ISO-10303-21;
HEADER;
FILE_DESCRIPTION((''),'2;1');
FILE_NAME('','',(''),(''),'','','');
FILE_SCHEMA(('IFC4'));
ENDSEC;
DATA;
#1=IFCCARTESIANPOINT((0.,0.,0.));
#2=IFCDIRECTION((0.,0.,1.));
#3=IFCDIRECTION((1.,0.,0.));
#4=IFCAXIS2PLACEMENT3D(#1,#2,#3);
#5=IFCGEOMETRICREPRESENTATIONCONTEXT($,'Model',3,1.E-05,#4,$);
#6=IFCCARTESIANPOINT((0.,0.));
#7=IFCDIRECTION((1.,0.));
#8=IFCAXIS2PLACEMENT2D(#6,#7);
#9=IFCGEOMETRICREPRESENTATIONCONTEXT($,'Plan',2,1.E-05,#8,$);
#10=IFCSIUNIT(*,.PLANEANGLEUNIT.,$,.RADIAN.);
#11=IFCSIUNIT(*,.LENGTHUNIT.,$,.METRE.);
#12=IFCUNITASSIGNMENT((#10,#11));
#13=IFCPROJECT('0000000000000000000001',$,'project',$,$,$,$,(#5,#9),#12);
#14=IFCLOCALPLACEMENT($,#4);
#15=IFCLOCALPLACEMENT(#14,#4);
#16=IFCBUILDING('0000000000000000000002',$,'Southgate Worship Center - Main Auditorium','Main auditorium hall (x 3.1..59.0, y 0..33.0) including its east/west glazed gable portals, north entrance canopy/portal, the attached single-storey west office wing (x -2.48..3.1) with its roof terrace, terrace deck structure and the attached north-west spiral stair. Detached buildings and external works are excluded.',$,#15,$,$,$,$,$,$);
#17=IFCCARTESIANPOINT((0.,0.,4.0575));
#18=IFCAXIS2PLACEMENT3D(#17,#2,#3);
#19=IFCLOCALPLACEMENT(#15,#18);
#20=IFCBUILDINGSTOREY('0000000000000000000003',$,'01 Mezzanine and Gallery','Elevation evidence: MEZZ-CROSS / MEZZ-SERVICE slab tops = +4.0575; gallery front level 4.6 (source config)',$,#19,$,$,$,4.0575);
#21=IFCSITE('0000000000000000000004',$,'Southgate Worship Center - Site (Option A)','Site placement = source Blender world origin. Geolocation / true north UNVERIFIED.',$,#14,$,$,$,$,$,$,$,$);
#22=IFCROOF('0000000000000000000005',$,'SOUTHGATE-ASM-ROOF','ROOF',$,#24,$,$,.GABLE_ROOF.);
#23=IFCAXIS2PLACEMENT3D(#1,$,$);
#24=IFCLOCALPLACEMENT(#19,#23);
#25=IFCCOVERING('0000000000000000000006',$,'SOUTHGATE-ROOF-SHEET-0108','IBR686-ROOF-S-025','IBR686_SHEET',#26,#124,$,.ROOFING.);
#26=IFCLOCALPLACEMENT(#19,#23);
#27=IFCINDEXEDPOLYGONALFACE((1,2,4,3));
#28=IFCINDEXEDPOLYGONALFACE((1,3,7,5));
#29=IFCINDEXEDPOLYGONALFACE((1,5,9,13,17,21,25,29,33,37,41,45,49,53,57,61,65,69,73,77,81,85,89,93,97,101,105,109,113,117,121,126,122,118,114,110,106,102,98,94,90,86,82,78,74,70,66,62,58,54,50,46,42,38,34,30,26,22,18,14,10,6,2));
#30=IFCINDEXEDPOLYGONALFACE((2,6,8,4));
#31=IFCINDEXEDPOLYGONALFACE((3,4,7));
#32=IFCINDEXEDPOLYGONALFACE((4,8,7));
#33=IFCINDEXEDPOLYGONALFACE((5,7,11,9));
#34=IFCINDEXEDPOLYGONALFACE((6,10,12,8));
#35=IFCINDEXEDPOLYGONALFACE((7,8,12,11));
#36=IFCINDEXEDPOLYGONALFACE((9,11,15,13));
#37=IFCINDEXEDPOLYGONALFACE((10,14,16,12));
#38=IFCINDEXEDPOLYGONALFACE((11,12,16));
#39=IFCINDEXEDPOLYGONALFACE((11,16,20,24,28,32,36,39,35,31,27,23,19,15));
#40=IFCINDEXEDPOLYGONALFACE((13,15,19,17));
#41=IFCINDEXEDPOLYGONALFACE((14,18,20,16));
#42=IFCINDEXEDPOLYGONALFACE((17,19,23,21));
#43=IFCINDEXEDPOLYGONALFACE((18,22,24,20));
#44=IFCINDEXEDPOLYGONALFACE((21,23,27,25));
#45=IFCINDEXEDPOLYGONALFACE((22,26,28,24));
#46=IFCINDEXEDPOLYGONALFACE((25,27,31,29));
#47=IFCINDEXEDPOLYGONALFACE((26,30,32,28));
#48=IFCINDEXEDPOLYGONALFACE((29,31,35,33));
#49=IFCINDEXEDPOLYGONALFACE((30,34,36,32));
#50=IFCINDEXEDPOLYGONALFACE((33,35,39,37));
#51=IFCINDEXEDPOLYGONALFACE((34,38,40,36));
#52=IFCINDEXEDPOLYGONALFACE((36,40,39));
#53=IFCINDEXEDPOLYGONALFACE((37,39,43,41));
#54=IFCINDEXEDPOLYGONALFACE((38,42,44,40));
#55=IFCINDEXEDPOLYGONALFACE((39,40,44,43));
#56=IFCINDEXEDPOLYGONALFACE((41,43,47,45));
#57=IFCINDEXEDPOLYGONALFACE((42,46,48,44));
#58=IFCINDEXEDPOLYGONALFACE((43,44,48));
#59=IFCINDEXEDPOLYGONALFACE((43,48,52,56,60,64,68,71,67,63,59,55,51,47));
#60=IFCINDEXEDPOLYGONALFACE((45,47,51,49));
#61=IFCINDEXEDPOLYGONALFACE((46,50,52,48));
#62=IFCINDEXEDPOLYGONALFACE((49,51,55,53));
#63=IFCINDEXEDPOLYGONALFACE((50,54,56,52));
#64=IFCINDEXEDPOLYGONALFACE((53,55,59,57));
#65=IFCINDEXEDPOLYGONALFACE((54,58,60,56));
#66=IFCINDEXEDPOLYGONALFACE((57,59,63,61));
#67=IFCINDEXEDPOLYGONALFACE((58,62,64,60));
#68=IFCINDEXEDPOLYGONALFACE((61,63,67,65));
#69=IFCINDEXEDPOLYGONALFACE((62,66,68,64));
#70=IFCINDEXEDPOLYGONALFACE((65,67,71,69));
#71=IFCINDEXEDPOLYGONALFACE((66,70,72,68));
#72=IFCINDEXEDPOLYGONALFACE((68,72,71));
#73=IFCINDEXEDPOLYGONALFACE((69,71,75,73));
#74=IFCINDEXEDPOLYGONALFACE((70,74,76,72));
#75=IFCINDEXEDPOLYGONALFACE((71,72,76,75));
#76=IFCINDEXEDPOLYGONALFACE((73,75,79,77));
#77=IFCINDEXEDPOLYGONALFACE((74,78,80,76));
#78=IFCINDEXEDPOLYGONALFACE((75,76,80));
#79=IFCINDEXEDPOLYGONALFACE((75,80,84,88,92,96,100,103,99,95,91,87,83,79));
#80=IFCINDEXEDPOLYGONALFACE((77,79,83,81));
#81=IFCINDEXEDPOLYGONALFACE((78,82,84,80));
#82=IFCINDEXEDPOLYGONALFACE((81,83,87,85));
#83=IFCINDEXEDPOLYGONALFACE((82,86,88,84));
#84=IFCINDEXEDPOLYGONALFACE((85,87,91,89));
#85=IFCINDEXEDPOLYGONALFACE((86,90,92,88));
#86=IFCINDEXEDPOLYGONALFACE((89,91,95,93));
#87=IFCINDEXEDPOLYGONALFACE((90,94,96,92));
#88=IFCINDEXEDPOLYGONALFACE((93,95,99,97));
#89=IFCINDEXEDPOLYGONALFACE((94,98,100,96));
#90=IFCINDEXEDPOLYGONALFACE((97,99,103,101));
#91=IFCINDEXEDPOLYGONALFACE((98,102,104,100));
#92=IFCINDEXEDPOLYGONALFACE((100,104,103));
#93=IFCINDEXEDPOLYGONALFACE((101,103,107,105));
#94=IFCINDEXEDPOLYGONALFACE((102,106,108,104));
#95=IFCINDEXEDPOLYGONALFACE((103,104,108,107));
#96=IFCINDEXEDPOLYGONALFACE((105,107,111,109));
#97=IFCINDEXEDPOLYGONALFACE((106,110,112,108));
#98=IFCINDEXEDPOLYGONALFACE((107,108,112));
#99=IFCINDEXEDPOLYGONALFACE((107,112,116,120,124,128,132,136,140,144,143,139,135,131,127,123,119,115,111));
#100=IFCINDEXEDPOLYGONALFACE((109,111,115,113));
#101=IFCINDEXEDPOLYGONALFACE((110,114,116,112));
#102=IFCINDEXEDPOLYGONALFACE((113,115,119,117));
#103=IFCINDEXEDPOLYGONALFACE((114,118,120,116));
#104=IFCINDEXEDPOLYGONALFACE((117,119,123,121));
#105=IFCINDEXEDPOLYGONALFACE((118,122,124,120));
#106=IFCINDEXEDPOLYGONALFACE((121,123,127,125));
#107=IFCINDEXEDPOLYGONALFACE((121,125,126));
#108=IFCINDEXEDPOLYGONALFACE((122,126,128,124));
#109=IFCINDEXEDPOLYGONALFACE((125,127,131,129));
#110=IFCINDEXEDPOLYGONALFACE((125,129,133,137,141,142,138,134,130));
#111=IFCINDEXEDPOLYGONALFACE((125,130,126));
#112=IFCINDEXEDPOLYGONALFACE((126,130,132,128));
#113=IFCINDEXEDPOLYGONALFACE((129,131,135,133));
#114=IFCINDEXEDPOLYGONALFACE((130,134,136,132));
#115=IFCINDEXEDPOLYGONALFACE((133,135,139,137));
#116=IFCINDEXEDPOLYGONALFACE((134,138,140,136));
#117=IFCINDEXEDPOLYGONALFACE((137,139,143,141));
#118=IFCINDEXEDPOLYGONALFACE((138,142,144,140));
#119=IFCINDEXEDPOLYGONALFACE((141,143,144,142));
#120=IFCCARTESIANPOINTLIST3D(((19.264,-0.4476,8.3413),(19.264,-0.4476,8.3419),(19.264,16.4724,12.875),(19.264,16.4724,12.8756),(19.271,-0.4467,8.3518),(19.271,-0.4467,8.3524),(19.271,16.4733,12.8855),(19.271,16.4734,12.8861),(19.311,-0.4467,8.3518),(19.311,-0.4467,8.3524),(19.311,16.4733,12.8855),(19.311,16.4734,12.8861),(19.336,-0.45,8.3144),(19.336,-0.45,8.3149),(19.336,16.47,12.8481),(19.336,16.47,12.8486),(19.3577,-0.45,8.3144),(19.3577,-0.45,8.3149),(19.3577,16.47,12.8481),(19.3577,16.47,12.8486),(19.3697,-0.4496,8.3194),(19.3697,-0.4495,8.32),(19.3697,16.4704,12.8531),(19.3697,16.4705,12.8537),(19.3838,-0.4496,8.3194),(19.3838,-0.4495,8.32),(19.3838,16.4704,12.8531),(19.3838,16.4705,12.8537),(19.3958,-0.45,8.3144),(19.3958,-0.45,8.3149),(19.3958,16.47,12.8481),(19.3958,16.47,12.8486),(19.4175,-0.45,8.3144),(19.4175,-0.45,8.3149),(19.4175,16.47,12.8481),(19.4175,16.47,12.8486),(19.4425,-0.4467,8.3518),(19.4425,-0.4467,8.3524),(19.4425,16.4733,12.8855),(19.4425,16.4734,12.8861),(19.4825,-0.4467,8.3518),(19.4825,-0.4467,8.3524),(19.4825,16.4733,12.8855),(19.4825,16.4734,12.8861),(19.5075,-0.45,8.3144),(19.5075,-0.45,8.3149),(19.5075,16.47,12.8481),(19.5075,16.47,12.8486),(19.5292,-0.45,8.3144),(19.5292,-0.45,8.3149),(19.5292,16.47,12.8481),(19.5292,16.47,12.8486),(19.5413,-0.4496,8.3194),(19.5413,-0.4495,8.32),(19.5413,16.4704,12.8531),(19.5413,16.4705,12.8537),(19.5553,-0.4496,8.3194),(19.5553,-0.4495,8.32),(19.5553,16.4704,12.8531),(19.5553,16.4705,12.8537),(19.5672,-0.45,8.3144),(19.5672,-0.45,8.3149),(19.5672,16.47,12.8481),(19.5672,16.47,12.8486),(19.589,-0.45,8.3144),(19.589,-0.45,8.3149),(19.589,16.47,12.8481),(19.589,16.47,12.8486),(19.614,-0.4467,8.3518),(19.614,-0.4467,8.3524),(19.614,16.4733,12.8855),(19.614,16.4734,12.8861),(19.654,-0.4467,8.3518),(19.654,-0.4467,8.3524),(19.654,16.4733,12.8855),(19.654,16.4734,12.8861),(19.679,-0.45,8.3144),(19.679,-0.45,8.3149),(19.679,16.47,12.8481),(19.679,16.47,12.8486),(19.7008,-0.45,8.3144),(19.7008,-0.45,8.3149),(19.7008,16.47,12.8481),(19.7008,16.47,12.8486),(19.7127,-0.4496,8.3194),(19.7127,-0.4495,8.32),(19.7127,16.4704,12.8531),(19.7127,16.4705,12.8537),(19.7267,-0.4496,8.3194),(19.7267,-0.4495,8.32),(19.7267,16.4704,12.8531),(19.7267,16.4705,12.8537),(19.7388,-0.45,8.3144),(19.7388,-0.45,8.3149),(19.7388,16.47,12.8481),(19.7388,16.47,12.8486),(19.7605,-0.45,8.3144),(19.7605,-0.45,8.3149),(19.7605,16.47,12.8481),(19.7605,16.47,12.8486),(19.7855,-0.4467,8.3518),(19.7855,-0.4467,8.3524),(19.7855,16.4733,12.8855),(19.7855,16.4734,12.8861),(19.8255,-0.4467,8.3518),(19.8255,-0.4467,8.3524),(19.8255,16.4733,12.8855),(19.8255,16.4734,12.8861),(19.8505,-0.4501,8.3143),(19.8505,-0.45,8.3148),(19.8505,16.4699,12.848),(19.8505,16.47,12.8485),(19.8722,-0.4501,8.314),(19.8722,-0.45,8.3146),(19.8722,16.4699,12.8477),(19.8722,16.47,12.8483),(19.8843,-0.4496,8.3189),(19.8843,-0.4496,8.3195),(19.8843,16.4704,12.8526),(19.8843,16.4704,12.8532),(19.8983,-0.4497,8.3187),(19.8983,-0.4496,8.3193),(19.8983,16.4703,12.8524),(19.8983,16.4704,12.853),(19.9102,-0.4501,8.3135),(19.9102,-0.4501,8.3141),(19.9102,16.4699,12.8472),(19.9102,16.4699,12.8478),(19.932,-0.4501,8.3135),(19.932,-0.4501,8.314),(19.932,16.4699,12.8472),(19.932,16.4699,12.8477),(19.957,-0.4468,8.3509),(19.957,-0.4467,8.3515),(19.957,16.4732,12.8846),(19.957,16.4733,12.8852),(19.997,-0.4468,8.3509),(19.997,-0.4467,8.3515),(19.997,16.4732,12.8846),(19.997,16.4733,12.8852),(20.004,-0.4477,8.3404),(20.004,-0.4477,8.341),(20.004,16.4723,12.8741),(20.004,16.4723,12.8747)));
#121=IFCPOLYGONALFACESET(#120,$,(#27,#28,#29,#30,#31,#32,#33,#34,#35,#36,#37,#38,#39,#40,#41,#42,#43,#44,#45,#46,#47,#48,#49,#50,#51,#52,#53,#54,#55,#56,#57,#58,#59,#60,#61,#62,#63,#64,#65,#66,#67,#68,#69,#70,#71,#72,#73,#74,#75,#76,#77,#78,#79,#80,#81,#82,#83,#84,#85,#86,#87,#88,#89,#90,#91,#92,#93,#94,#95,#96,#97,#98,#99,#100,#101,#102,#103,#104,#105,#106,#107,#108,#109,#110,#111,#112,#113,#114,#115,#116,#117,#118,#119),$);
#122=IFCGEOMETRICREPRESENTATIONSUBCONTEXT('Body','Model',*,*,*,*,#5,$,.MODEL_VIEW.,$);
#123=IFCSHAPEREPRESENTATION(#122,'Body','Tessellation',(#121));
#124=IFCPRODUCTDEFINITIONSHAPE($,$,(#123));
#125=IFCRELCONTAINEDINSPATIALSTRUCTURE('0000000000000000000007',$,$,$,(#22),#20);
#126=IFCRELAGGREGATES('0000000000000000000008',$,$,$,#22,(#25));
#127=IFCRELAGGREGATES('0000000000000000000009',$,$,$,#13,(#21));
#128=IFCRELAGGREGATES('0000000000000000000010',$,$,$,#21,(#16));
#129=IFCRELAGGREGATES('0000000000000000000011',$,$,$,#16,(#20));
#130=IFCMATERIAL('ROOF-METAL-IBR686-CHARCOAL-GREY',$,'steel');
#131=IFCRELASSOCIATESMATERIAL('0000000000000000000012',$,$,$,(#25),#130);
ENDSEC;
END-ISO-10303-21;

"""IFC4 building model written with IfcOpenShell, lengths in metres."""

from ifc_helpers import new_model, si_unit, frame, origin_with_axes, origin_2d_with_axis, place, context, subcontext, project, spatial, indexed_curve, outline, extrude, clip, halfspace, material, element, aggregate, save


model = new_model("IFC4")

# Units and contexts
model_context = context("Model", 3, precision=1e-05, world=origin_with_axes())
plan_context = context("Plan", 2, precision=1e-05, world=origin_2d_with_axis())
body_context = subcontext(model_context, "Body", "Model", "MODEL_VIEW")
ifc_project = project(units=[si_unit("PLANEANGLEUNIT", "RADIAN"), si_unit("LENGTHUNIT", "METRE")], contexts=[model_context, plan_context])

# Site, building, storey
site_placement = place(None, origin_with_axes())
site = spatial("IfcSite", under=ifc_project, at=site_placement, Name="Southgate Worship Center - Site (Option A)", Description="Site placement = source Blender world origin. Geolocation / true north UNVERIFIED.")
building_placement = place(site_placement, origin_with_axes())
building = spatial("IfcBuilding", under=site, at=building_placement, Name="Southgate Worship Center - Main Auditorium", Description="Main auditorium hall (x 3.1..59.0, y 0..33.0) including its east/west glazed gable portals, north entrance canopy/portal, the attached single-storey west office wing (x -2.48..3.1) with its roof terrace, terrace deck structure and the attached north-west spiral stair. Detached buildings and external works are excluded.")
storey_placement = place(building_placement, frame((0.0, 0.0, 4.0575), z_axis=(0.0, 0.0, 1.0), x_axis=(1.0, 0.0, 0.0)))
storey = spatial("IfcBuildingStorey", under=building, at=storey_placement, Name="01 Mezzanine and Gallery", Description="Elevation evidence: MEZZ-CROSS / MEZZ-SERVICE slab tops = +4.0575; gallery front level 4.6 (source config)", Elevation=4.0575)

# Roof, covering
roof_placement = place(storey_placement, origin_with_axes())
roof = element("IfcRoof", 1, at=roof_placement, inside=storey, Name="SOUTHGATE-ASM-ROOF", Description="ROOF", PredefinedType="GABLE_ROOF")
ifc_material_1 = material(Name="ROOF-METAL-IBR686-CHARCOAL-GREY", Category="steel")
covering_1_placement = place(roof_placement, frame((19.264, -0.4501, 8.3135), z_axis=(0.0, 0.0, 1.0), x_axis=(1.0, 0.0, 0.0)))
covering_1 = element("IfcCovering", 2, at=covering_1_placement, material=ifc_material_1, Name="SOUTHGATE-ROOF-SHEET-0108", Description="IBR686-ROOF-S-025", ObjectType="IBR686_SHEET", PredefinedType="ROOFING", context=body_context, shape_type="Clipping", body=[
    clip(clip(extrude(outline(indexed_curve([(0.0, 0.0), (0.025, 0.0353), (0.065, 0.0353), (0.072, 0.0254), (0.072, 0.0259), (0.065, 0.0358), (0.025, 0.0358), (0.0, 0.0005), (-0.0217, 0.0005), (-0.0337, 0.0053), (-0.0478, 0.0053), (-0.0597, 0.0005), (-0.0815, 0.0005), (-0.1065, 0.0358), (-0.1465, 0.0358), (-0.1715, 0.0005), (-0.1932, 0.0005), (-0.2052, 0.0053), (-0.2192, 0.0053), (-0.2312, 0.0005), (-0.253, 0.0005), (-0.278, 0.0358), (-0.318, 0.0358), (-0.343, 0.0005), (-0.3647, 0.0005), (-0.3767, 0.0053), (-0.3907, 0.0053), (-0.4028, 0.0005), (-0.4245, 0.0005), (-0.4495, 0.0358), (-0.4895, 0.0358), (-0.5145, 0.0004), (-0.5362, 0.0002), (-0.5483, 0.0048), (-0.5623, 0.0046), (-0.5742, -0.0003), (-0.596, -0.0004), (-0.621, 0.0349), (-0.661, 0.0349), (-0.668, 0.0251), (-0.668, 0.0246), (-0.661, 0.0344), (-0.621, 0.0344), (-0.596, -0.0009), (-0.5742, -0.0008), (-0.5623, 0.0041), (-0.5483, 0.0043), (-0.5362, -0.0003), (-0.5145, -0.0001), (-0.4895, 0.0353), (-0.4495, 0.0353), (-0.4245, 0.0), (-0.4028, 0.0), (-0.3907, 0.0048), (-0.3767, 0.0048), (-0.3647, 0.0), (-0.343, 0.0), (-0.318, 0.0353), (-0.278, 0.0353), (-0.253, 0.0), (-0.2312, 0.0), (-0.2192, 0.0048), (-0.2052, 0.0048), (-0.1932, 0.0), (-0.1715, 0.0), (-0.1465, 0.0353), (-0.1065, 0.0353), (-0.0815, 0.0), (-0.0597, 0.0), (-0.0478, 0.0048), (-0.0337, 0.0048), (-0.0217, 0.0), (0.0, 0.0)], self_intersect=False)), frame((0.072, -0.0003, 0.0008), z_axis=(0.0, 0.965926, 0.258819), x_axis=(-1.0, 0.0, 0.0)), (0.0, 0.0, 1.0), 17.5303), halfspace(frame((0.37, 0.0012, 0.014), z_axis=(0.0, -0.996022, 0.089113), x_axis=(1.0, 0.0, 0.0)), False)), halfspace(frame((0.37, 16.9212, 4.5477), z_axis=(0.0, 0.996021, -0.089119), x_axis=(-1.0, 0.0, 0.0)), False)),
])
aggregate(roof, [covering_1])

save(model, "model.ifc")
